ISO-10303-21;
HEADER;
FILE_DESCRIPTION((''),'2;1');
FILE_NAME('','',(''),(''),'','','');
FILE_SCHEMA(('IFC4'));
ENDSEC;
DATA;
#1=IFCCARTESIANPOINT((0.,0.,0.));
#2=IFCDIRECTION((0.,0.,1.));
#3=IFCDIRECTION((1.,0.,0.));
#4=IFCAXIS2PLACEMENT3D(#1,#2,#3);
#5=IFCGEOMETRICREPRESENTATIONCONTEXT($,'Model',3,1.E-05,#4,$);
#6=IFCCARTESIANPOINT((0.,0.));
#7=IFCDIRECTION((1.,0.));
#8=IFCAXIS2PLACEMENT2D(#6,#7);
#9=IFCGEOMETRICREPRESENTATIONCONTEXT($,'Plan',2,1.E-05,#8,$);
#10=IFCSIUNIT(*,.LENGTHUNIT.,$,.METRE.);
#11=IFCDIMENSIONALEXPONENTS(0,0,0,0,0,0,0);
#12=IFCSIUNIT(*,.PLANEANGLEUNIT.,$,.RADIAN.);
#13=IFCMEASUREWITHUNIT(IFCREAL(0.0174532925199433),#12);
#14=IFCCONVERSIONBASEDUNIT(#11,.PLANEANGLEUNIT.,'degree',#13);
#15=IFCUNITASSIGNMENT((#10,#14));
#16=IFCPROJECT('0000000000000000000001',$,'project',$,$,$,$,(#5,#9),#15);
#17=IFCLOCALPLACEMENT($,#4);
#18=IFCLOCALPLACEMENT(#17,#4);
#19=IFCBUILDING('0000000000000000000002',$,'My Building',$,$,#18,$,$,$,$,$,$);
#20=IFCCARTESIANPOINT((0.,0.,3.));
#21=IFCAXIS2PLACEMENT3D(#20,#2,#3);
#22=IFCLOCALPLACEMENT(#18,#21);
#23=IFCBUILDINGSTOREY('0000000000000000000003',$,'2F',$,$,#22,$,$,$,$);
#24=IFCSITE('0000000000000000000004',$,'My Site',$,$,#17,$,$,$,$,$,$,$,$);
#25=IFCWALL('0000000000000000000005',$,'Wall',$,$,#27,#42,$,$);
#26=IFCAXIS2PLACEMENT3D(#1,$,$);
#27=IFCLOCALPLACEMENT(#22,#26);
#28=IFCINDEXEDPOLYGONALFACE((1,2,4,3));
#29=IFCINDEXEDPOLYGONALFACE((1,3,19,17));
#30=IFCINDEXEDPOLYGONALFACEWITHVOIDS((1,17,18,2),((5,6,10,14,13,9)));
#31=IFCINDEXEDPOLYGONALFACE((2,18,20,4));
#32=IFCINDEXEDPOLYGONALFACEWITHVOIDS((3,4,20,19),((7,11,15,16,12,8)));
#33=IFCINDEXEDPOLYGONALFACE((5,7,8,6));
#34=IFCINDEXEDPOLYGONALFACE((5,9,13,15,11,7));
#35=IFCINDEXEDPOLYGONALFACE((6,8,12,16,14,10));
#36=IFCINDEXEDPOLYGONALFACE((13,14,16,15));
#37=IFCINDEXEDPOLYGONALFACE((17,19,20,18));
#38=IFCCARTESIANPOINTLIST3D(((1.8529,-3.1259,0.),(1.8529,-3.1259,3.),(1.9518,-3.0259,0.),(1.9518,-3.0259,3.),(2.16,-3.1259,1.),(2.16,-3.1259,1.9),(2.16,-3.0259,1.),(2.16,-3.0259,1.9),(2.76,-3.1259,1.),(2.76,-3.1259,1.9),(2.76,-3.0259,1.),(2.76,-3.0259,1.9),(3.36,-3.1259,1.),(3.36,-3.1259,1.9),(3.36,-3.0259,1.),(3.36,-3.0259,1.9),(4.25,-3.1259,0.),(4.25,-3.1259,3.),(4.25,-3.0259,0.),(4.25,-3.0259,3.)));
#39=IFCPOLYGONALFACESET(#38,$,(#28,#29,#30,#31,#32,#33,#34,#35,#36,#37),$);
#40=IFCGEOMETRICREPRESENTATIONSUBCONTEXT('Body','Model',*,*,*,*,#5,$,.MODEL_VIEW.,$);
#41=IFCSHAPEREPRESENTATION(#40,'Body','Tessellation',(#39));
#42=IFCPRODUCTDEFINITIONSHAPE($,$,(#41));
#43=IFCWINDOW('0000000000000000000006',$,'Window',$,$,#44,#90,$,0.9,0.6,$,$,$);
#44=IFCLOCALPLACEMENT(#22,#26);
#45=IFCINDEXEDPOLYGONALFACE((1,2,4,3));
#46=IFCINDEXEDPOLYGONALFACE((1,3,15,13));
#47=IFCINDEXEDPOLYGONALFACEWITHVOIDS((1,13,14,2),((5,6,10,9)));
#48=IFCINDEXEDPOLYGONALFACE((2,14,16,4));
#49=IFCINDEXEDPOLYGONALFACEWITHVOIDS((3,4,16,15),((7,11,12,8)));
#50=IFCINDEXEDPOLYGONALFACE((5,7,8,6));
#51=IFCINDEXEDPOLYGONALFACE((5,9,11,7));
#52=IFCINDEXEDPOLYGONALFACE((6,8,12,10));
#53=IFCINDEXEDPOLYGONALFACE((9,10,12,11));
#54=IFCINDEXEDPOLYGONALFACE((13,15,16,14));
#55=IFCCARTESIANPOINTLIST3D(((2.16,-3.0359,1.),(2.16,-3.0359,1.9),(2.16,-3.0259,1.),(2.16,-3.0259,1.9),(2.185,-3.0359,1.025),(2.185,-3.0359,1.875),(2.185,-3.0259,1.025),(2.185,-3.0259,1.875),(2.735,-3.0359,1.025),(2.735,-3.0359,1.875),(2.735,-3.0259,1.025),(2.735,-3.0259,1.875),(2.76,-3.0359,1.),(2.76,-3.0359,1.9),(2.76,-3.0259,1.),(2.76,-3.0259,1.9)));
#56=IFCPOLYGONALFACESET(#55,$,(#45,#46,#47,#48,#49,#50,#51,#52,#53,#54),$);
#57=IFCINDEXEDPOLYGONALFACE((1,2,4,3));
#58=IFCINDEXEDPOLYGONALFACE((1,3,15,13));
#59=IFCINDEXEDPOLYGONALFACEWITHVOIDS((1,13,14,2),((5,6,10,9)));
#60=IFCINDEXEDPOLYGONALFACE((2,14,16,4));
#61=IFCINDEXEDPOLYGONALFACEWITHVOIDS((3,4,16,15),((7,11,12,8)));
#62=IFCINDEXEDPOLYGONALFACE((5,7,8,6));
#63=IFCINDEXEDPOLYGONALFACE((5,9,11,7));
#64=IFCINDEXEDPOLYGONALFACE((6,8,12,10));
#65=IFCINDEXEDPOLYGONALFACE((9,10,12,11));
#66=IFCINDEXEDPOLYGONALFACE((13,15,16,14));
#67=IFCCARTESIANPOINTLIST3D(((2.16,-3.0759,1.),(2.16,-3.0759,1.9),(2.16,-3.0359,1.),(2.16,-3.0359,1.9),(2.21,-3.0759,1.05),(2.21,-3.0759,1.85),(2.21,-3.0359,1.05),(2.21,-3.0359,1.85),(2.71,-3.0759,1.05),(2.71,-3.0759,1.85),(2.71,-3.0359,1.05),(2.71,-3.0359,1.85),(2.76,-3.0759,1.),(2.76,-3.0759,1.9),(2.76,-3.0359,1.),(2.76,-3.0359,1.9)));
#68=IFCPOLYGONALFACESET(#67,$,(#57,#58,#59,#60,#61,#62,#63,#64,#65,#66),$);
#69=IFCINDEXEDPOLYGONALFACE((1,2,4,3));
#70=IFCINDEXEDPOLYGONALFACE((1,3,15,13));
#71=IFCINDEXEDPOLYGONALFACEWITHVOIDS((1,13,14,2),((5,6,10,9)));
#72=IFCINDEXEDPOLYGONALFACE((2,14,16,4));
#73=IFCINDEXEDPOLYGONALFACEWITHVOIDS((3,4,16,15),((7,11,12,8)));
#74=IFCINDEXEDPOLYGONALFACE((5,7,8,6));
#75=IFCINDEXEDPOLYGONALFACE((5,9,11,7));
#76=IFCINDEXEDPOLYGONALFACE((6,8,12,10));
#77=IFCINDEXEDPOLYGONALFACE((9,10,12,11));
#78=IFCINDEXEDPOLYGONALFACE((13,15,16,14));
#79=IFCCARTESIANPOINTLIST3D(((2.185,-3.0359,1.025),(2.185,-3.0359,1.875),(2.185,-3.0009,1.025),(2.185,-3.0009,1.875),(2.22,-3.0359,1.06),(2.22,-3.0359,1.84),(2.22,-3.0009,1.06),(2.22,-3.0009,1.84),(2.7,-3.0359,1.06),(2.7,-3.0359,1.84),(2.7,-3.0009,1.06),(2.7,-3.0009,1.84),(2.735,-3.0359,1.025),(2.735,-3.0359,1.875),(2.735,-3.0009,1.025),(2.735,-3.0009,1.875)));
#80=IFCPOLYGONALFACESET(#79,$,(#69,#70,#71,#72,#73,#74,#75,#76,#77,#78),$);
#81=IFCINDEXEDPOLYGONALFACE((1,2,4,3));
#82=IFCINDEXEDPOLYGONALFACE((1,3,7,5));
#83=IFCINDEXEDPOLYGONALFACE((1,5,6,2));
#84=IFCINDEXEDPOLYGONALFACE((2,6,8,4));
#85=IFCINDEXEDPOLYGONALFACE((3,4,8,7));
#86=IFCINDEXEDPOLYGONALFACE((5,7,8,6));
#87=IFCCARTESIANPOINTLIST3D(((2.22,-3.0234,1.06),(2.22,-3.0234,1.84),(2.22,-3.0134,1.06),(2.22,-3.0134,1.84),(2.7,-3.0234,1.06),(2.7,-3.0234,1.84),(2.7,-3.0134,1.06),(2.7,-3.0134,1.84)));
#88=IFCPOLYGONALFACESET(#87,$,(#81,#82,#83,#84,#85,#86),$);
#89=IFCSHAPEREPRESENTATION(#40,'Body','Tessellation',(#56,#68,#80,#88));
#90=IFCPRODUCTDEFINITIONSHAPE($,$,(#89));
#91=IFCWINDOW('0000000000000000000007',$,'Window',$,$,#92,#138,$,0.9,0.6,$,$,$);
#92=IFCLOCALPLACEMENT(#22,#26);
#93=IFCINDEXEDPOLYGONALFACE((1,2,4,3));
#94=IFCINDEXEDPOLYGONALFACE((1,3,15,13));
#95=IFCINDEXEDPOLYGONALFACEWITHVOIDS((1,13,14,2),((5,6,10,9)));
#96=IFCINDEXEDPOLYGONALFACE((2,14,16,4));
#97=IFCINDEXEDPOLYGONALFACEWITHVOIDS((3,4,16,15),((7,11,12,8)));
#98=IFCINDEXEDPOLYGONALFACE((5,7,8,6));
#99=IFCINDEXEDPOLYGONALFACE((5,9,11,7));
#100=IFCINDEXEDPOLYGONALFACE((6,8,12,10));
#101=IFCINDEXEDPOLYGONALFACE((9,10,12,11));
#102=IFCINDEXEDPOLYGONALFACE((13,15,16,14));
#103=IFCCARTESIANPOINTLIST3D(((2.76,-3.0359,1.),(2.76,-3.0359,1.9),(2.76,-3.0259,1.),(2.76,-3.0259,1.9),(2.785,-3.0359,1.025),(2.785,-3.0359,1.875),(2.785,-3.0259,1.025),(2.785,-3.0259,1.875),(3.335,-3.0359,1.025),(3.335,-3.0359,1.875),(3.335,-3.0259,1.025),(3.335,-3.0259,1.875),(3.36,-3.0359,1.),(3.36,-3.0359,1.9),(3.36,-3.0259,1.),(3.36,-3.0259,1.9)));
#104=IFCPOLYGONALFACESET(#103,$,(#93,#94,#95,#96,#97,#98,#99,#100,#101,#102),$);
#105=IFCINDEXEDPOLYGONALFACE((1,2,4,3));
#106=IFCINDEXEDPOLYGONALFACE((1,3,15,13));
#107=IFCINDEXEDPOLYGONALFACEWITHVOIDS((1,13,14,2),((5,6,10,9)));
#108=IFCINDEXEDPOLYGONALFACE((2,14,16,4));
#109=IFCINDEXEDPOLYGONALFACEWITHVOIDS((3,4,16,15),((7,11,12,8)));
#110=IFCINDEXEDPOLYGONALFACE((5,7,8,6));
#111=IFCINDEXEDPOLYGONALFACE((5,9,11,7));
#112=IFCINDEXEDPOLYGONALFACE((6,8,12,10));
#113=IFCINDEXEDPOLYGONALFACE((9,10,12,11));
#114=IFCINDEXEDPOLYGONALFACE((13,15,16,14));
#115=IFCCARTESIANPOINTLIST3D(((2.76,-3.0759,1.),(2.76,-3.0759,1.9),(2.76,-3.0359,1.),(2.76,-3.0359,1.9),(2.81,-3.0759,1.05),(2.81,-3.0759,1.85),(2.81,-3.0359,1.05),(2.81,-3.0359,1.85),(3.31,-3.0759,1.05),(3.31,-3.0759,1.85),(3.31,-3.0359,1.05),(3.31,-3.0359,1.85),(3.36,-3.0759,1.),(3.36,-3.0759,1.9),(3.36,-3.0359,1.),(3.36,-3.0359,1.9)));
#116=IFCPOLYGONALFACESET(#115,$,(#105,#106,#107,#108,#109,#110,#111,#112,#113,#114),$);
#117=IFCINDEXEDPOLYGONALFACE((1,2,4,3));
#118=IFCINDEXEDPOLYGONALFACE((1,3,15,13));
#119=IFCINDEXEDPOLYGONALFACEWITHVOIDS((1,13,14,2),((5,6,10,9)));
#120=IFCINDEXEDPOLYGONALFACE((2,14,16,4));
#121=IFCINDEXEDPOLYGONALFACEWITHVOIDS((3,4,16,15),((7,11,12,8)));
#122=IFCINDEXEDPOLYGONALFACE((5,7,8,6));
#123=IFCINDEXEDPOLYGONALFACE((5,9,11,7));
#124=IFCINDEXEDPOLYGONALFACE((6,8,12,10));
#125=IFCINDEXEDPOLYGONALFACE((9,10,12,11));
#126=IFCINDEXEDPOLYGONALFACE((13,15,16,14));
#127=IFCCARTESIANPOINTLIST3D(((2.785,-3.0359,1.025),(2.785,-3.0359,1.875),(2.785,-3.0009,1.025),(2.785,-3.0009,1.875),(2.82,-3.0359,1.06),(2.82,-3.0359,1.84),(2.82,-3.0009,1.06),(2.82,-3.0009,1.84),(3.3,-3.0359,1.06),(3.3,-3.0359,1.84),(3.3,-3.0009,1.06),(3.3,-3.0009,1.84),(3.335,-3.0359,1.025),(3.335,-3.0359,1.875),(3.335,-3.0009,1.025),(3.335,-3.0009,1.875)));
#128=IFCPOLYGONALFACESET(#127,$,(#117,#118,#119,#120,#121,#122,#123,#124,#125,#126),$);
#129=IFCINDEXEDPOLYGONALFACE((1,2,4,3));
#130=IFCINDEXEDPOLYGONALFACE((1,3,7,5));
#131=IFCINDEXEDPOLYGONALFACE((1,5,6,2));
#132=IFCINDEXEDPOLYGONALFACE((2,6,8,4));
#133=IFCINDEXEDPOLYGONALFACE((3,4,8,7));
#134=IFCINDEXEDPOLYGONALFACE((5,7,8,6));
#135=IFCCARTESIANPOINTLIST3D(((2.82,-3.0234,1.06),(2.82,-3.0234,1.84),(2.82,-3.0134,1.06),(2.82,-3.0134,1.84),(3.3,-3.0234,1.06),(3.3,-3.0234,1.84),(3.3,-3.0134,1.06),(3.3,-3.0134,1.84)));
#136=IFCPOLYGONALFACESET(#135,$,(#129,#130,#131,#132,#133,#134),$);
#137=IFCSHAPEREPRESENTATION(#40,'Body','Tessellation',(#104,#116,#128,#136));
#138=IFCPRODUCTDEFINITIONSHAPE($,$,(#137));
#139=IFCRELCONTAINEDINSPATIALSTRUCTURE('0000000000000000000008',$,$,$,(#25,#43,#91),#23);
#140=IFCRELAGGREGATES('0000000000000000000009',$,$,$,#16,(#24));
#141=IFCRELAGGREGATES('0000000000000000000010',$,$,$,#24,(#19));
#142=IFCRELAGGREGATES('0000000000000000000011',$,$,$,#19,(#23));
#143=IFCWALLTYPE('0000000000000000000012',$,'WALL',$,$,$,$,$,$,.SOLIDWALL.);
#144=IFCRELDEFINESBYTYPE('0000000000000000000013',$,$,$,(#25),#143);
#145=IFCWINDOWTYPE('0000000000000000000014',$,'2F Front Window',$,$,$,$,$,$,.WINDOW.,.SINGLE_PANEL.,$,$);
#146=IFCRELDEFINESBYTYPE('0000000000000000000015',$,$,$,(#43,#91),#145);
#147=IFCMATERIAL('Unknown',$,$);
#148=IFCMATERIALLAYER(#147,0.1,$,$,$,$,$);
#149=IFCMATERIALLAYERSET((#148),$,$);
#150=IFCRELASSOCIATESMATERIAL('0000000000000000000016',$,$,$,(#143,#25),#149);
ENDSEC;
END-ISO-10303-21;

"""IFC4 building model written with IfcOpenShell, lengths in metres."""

from ifc_helpers import new_model, entity, si_unit, converted_unit, frame, origin_with_axes, origin_2d_with_axis, place, context, subcontext, project, spatial, line, indexed_curve, outline, extrude, shape, source, transform, mapped, material, layer, layer_set, layer_usage, type_object, type_shapes, element, fill, save


model = new_model("IFC4")

# Units and contexts
model_context = context("Model", 3, precision=1e-05, world=origin_with_axes())
plan_context = context("Plan", 2, precision=1e-05, world=origin_2d_with_axis())
body_context_1 = subcontext(model_context, "Body", "Model", "MODEL_VIEW")
body_context_2 = subcontext(plan_context, "Body", "Plan", "PLAN_VIEW")
ifc_project = project(units=[si_unit("LENGTHUNIT", "METRE"), converted_unit("PLANEANGLEUNIT", "degree", entity("IfcReal", 0.0174532925199433), si_unit("PLANEANGLEUNIT", "RADIAN"), dimensions=[0, 0, 0, 0, 0, 0, 0])], contexts=[model_context, plan_context])

# Site, building, storey
site_placement = place(None, origin_with_axes())
site = spatial("IfcSite", under=ifc_project, at=site_placement, Name="My Site")
building_placement = place(site_placement, origin_with_axes())
building = spatial("IfcBuilding", under=site, at=building_placement, Name="My Building")
storey_placement = place(building_placement, frame((0.0, 0.0, 3.0), z_axis=(0.0, 0.0, 1.0), x_axis=(1.0, 0.0, 0.0)))
storey = spatial("IfcBuildingStorey", under=building, at=storey_placement, Name="2F")

# Shared definitions
ifc_material = material(Name="Unknown")
ifc_layer = layer(ifc_material, 0.1)
ifc_layer_set = layer_set([ifc_layer])
wall_type = type_object("IfcWallType", Name="WALL", PredefinedType="SOLIDWALL", material=ifc_layer_set)

# Wall, openings, windows
ifc_layer_usage_1 = layer_usage(ifc_layer_set, "AXIS2", "POSITIVE", 0.0)
wall_1_placement = place(storey_placement, frame((1.8529, -3.1259, 0.0), z_axis=(0.0, 0.0, 1.0), x_axis=(1.0, 0.0, 0.0)))
wall_1 = element("IfcWall", 1, at=wall_1_placement, inside=storey, type_object=wall_type, material=ifc_layer_usage_1, Name="Wall", context=body_context_1, shape_type="SweptSolid", body=[
    extrude(outline(indexed_curve([(0.0, 0.0), (0.0989, 0.1), (2.3971, 0.1), (2.3971, 0.0)], segments=[line(1, 2, 3, 4, 1)])), origin_with_axes(), (0.0, 0.0, 1.0), 3.0),
])
shared_shape_1 = source(origin_with_axes(), body_context_1, "Body", "SweptSolid", [
    extrude(outline(indexed_curve([(0.0, 0.0), (0.6, 0.0), (0.6, 0.9), (0.0, 0.9)], segments=[line(1, 2, 3, 4, 1)])), frame((0.0, -0.6, 0.0), z_axis=(0.0, -1.0, 0.0), x_axis=(1.0, 0.0, 0.0)), (0.0, 0.0, -1.0), 1.2),
])
opening_1_placement = place(wall_1_placement, frame((0.3071, 0.0, 1.0), z_axis=(0.0, 0.0, 1.0), x_axis=(1.0, 0.0, 0.0)))
opening_1 = element("IfcOpeningElement", 2, at=opening_1_placement, cuts=wall_1, PredefinedType="OPENING", context=body_context_1, shape_type="MappedRepresentation", body=[
    mapped(shared_shape_1, transform((0.0, 0.0, 0.0), x_axis=(1.0, 0.0, 0.0), y_axis=(0.0, 1.0, 0.0), z_axis=(0.0, 0.0, 1.0), scale=1.0)),
])
opening_2_placement = place(wall_1_placement, frame((0.9071, 0.0, 1.0), z_axis=(0.0, 0.0, 1.0), x_axis=(1.0, 0.0, 0.0)))
opening_2 = element("IfcOpeningElement", 3, at=opening_2_placement, cuts=wall_1, PredefinedType="OPENING", context=body_context_1, shape_type="MappedRepresentation", body=[
    mapped(shared_shape_1, transform((0.0, 0.0, 0.0), x_axis=(1.0, 0.0, 0.0), y_axis=(0.0, 1.0, 0.0), z_axis=(0.0, 0.0, 1.0), scale=1.0)),
])
window_type_1 = type_object("IfcWindowType", Name="2F Front Window", PartitioningType="SINGLE_PANEL", PredefinedType="WINDOW")
shared_shape_2 = source(origin_with_axes(), body_context_1, "Body", "SweptSolid", [
    extrude(outline(indexed_curve([(0.0, 0.0), (0.6, 0.0), (0.6, 0.9), (0.0, 0.9)], segments=[line(1, 2, 3, 4, 1)]), holes=[indexed_curve([(0.025, 0.025), (0.575, 0.025), (0.575, 0.875), (0.025, 0.875)], segments=[line(1, 2, 3, 4, 1)])]), frame((0.0, 0.09, 0.0), z_axis=(0.0, -1.0, 0.0), x_axis=(1.0, 0.0, 0.0)), (0.0, 0.0, -1.0), 0.01),
    extrude(outline(indexed_curve([(0.0, 0.0), (0.6, 0.0), (0.6, 0.9), (0.0, 0.9)], segments=[line(1, 2, 3, 4, 1)]), holes=[indexed_curve([(0.05, 0.05), (0.55, 0.05), (0.55, 0.85), (0.05, 0.85)], segments=[line(1, 2, 3, 4, 1)])]), frame((0.0, 0.05, 0.0), z_axis=(0.0, -1.0, 0.0), x_axis=(1.0, 0.0, 0.0)), (0.0, 0.0, -1.0), 0.04),
    extrude(outline(indexed_curve([(0.0, 0.0), (0.55, 0.0), (0.55, 0.85), (0.0, 0.85)], segments=[line(1, 2, 3, 4, 1)]), holes=[indexed_curve([(0.035, 0.035), (0.515, 0.035), (0.515, 0.815), (0.035, 0.815)], segments=[line(1, 2, 3, 4, 1)])]), frame((0.025, 0.09, 0.025), z_axis=(0.0, -1.0, 0.0), x_axis=(1.0, 0.0, 0.0)), (0.0, 0.0, -1.0), 0.035),
    extrude(outline(indexed_curve([(0.035, 0.035), (0.515, 0.035), (0.515, 0.815), (0.035, 0.815)], segments=[line(1, 2, 3, 4, 1)])), frame((0.025, 0.1025, 0.025), z_axis=(0.0, -1.0, 0.0), x_axis=(1.0, 0.0, 0.0)), (0.0, 0.0, -1.0), 0.01),
])
shared_shape_3 = source(origin_with_axes(), body_context_2, "Body", "Curve2D", [
    entity("IfcIndexedPolyCurve", entity("IfcCartesianPointList2D", [[0.05, 0.05], [0.55, 0.05]])),
    entity("IfcIndexedPolyCurve", entity("IfcCartesianPointList2D", [[0.0, 0.1], [0.025, 0.1], [0.025, 0.09], [0.05, 0.09], [0.05, 0.05], [0.0, 0.05]]), [entity("IfcLineIndex", [1, 2, 3, 4, 5, 6, 1])]),
    entity("IfcIndexedPolyCurve", entity("IfcCartesianPointList2D", [[0.6, 0.1], [0.575, 0.1], [0.575, 0.09], [0.55, 0.09], [0.55, 0.05], [0.6, 0.05]]), [entity("IfcLineIndex", [1, 2, 3, 4, 5, 6, 1])]),
    entity("IfcIndexedPolyCurve", entity("IfcCartesianPointList2D", [[0.025, 0.09], [0.06, 0.09], [0.06, 0.125], [0.025, 0.125]]), [entity("IfcLineIndex", [1, 2, 3, 4, 1])]),
    entity("IfcIndexedPolyCurve", entity("IfcCartesianPointList2D", [[0.575, 0.09], [0.54, 0.09], [0.54, 0.125], [0.575, 0.125]]), [entity("IfcLineIndex", [1, 2, 3, 4, 1])]),
    entity("IfcIndexedPolyCurve", entity("IfcCartesianPointList2D", [[0.06, 0.09], [0.54, 0.09]])),
    entity("IfcIndexedPolyCurve", entity("IfcCartesianPointList2D", [[0.06, 0.125], [0.54, 0.125]])),
    entity("IfcIndexedPolyCurve", entity("IfcCartesianPointList2D", [[0.06, 0.1075], [0.54, 0.1075]])),
])
type_shapes(window_type_1, [shared_shape_2, shared_shape_3])
window_1_placement = place(opening_1_placement, origin_with_axes())
window_1 = element("IfcWindow", 4, at=window_1_placement, inside=storey, type_object=window_type_1, Name="Window", OverallHeight=0.9, OverallWidth=0.6, shapes=[
    shape(body_context_1, "Body", "MappedRepresentation", [mapped(shared_shape_2, transform((0.0, 0.0, 0.0), x_axis=(1.0, 0.0, 0.0), y_axis=(0.0, 1.0, 0.0), z_axis=(0.0, 0.0, 1.0), scale=1.0))]),
    shape(body_context_2, "Body", "MappedRepresentation", [mapped(shared_shape_3, transform((0.0, 0.0, 0.0), x_axis=(1.0, 0.0, 0.0), y_axis=(0.0, 1.0, 0.0), z_axis=(0.0, 0.0, 1.0), scale=1.0))]),
])
fill(opening_1, window_1)
window_2_placement = place(opening_2_placement, origin_with_axes())
window_2 = element("IfcWindow", 5, at=window_2_placement, inside=storey, type_object=window_type_1, Name="Window", OverallHeight=0.9, OverallWidth=0.6, shapes=[
    shape(body_context_1, "Body", "MappedRepresentation", [mapped(shared_shape_2, transform((0.0, 0.0, 0.0), x_axis=(1.0, 0.0, 0.0), y_axis=(0.0, 1.0, 0.0), z_axis=(0.0, 0.0, 1.0), scale=1.0))]),
    shape(body_context_2, "Body", "MappedRepresentation", [mapped(shared_shape_3, transform((0.0, 0.0, 0.0), x_axis=(1.0, 0.0, 0.0), y_axis=(0.0, 1.0, 0.0), z_axis=(0.0, 0.0, 1.0), scale=1.0))]),
])
fill(opening_2, window_2)

save(model, "model.ifc")
